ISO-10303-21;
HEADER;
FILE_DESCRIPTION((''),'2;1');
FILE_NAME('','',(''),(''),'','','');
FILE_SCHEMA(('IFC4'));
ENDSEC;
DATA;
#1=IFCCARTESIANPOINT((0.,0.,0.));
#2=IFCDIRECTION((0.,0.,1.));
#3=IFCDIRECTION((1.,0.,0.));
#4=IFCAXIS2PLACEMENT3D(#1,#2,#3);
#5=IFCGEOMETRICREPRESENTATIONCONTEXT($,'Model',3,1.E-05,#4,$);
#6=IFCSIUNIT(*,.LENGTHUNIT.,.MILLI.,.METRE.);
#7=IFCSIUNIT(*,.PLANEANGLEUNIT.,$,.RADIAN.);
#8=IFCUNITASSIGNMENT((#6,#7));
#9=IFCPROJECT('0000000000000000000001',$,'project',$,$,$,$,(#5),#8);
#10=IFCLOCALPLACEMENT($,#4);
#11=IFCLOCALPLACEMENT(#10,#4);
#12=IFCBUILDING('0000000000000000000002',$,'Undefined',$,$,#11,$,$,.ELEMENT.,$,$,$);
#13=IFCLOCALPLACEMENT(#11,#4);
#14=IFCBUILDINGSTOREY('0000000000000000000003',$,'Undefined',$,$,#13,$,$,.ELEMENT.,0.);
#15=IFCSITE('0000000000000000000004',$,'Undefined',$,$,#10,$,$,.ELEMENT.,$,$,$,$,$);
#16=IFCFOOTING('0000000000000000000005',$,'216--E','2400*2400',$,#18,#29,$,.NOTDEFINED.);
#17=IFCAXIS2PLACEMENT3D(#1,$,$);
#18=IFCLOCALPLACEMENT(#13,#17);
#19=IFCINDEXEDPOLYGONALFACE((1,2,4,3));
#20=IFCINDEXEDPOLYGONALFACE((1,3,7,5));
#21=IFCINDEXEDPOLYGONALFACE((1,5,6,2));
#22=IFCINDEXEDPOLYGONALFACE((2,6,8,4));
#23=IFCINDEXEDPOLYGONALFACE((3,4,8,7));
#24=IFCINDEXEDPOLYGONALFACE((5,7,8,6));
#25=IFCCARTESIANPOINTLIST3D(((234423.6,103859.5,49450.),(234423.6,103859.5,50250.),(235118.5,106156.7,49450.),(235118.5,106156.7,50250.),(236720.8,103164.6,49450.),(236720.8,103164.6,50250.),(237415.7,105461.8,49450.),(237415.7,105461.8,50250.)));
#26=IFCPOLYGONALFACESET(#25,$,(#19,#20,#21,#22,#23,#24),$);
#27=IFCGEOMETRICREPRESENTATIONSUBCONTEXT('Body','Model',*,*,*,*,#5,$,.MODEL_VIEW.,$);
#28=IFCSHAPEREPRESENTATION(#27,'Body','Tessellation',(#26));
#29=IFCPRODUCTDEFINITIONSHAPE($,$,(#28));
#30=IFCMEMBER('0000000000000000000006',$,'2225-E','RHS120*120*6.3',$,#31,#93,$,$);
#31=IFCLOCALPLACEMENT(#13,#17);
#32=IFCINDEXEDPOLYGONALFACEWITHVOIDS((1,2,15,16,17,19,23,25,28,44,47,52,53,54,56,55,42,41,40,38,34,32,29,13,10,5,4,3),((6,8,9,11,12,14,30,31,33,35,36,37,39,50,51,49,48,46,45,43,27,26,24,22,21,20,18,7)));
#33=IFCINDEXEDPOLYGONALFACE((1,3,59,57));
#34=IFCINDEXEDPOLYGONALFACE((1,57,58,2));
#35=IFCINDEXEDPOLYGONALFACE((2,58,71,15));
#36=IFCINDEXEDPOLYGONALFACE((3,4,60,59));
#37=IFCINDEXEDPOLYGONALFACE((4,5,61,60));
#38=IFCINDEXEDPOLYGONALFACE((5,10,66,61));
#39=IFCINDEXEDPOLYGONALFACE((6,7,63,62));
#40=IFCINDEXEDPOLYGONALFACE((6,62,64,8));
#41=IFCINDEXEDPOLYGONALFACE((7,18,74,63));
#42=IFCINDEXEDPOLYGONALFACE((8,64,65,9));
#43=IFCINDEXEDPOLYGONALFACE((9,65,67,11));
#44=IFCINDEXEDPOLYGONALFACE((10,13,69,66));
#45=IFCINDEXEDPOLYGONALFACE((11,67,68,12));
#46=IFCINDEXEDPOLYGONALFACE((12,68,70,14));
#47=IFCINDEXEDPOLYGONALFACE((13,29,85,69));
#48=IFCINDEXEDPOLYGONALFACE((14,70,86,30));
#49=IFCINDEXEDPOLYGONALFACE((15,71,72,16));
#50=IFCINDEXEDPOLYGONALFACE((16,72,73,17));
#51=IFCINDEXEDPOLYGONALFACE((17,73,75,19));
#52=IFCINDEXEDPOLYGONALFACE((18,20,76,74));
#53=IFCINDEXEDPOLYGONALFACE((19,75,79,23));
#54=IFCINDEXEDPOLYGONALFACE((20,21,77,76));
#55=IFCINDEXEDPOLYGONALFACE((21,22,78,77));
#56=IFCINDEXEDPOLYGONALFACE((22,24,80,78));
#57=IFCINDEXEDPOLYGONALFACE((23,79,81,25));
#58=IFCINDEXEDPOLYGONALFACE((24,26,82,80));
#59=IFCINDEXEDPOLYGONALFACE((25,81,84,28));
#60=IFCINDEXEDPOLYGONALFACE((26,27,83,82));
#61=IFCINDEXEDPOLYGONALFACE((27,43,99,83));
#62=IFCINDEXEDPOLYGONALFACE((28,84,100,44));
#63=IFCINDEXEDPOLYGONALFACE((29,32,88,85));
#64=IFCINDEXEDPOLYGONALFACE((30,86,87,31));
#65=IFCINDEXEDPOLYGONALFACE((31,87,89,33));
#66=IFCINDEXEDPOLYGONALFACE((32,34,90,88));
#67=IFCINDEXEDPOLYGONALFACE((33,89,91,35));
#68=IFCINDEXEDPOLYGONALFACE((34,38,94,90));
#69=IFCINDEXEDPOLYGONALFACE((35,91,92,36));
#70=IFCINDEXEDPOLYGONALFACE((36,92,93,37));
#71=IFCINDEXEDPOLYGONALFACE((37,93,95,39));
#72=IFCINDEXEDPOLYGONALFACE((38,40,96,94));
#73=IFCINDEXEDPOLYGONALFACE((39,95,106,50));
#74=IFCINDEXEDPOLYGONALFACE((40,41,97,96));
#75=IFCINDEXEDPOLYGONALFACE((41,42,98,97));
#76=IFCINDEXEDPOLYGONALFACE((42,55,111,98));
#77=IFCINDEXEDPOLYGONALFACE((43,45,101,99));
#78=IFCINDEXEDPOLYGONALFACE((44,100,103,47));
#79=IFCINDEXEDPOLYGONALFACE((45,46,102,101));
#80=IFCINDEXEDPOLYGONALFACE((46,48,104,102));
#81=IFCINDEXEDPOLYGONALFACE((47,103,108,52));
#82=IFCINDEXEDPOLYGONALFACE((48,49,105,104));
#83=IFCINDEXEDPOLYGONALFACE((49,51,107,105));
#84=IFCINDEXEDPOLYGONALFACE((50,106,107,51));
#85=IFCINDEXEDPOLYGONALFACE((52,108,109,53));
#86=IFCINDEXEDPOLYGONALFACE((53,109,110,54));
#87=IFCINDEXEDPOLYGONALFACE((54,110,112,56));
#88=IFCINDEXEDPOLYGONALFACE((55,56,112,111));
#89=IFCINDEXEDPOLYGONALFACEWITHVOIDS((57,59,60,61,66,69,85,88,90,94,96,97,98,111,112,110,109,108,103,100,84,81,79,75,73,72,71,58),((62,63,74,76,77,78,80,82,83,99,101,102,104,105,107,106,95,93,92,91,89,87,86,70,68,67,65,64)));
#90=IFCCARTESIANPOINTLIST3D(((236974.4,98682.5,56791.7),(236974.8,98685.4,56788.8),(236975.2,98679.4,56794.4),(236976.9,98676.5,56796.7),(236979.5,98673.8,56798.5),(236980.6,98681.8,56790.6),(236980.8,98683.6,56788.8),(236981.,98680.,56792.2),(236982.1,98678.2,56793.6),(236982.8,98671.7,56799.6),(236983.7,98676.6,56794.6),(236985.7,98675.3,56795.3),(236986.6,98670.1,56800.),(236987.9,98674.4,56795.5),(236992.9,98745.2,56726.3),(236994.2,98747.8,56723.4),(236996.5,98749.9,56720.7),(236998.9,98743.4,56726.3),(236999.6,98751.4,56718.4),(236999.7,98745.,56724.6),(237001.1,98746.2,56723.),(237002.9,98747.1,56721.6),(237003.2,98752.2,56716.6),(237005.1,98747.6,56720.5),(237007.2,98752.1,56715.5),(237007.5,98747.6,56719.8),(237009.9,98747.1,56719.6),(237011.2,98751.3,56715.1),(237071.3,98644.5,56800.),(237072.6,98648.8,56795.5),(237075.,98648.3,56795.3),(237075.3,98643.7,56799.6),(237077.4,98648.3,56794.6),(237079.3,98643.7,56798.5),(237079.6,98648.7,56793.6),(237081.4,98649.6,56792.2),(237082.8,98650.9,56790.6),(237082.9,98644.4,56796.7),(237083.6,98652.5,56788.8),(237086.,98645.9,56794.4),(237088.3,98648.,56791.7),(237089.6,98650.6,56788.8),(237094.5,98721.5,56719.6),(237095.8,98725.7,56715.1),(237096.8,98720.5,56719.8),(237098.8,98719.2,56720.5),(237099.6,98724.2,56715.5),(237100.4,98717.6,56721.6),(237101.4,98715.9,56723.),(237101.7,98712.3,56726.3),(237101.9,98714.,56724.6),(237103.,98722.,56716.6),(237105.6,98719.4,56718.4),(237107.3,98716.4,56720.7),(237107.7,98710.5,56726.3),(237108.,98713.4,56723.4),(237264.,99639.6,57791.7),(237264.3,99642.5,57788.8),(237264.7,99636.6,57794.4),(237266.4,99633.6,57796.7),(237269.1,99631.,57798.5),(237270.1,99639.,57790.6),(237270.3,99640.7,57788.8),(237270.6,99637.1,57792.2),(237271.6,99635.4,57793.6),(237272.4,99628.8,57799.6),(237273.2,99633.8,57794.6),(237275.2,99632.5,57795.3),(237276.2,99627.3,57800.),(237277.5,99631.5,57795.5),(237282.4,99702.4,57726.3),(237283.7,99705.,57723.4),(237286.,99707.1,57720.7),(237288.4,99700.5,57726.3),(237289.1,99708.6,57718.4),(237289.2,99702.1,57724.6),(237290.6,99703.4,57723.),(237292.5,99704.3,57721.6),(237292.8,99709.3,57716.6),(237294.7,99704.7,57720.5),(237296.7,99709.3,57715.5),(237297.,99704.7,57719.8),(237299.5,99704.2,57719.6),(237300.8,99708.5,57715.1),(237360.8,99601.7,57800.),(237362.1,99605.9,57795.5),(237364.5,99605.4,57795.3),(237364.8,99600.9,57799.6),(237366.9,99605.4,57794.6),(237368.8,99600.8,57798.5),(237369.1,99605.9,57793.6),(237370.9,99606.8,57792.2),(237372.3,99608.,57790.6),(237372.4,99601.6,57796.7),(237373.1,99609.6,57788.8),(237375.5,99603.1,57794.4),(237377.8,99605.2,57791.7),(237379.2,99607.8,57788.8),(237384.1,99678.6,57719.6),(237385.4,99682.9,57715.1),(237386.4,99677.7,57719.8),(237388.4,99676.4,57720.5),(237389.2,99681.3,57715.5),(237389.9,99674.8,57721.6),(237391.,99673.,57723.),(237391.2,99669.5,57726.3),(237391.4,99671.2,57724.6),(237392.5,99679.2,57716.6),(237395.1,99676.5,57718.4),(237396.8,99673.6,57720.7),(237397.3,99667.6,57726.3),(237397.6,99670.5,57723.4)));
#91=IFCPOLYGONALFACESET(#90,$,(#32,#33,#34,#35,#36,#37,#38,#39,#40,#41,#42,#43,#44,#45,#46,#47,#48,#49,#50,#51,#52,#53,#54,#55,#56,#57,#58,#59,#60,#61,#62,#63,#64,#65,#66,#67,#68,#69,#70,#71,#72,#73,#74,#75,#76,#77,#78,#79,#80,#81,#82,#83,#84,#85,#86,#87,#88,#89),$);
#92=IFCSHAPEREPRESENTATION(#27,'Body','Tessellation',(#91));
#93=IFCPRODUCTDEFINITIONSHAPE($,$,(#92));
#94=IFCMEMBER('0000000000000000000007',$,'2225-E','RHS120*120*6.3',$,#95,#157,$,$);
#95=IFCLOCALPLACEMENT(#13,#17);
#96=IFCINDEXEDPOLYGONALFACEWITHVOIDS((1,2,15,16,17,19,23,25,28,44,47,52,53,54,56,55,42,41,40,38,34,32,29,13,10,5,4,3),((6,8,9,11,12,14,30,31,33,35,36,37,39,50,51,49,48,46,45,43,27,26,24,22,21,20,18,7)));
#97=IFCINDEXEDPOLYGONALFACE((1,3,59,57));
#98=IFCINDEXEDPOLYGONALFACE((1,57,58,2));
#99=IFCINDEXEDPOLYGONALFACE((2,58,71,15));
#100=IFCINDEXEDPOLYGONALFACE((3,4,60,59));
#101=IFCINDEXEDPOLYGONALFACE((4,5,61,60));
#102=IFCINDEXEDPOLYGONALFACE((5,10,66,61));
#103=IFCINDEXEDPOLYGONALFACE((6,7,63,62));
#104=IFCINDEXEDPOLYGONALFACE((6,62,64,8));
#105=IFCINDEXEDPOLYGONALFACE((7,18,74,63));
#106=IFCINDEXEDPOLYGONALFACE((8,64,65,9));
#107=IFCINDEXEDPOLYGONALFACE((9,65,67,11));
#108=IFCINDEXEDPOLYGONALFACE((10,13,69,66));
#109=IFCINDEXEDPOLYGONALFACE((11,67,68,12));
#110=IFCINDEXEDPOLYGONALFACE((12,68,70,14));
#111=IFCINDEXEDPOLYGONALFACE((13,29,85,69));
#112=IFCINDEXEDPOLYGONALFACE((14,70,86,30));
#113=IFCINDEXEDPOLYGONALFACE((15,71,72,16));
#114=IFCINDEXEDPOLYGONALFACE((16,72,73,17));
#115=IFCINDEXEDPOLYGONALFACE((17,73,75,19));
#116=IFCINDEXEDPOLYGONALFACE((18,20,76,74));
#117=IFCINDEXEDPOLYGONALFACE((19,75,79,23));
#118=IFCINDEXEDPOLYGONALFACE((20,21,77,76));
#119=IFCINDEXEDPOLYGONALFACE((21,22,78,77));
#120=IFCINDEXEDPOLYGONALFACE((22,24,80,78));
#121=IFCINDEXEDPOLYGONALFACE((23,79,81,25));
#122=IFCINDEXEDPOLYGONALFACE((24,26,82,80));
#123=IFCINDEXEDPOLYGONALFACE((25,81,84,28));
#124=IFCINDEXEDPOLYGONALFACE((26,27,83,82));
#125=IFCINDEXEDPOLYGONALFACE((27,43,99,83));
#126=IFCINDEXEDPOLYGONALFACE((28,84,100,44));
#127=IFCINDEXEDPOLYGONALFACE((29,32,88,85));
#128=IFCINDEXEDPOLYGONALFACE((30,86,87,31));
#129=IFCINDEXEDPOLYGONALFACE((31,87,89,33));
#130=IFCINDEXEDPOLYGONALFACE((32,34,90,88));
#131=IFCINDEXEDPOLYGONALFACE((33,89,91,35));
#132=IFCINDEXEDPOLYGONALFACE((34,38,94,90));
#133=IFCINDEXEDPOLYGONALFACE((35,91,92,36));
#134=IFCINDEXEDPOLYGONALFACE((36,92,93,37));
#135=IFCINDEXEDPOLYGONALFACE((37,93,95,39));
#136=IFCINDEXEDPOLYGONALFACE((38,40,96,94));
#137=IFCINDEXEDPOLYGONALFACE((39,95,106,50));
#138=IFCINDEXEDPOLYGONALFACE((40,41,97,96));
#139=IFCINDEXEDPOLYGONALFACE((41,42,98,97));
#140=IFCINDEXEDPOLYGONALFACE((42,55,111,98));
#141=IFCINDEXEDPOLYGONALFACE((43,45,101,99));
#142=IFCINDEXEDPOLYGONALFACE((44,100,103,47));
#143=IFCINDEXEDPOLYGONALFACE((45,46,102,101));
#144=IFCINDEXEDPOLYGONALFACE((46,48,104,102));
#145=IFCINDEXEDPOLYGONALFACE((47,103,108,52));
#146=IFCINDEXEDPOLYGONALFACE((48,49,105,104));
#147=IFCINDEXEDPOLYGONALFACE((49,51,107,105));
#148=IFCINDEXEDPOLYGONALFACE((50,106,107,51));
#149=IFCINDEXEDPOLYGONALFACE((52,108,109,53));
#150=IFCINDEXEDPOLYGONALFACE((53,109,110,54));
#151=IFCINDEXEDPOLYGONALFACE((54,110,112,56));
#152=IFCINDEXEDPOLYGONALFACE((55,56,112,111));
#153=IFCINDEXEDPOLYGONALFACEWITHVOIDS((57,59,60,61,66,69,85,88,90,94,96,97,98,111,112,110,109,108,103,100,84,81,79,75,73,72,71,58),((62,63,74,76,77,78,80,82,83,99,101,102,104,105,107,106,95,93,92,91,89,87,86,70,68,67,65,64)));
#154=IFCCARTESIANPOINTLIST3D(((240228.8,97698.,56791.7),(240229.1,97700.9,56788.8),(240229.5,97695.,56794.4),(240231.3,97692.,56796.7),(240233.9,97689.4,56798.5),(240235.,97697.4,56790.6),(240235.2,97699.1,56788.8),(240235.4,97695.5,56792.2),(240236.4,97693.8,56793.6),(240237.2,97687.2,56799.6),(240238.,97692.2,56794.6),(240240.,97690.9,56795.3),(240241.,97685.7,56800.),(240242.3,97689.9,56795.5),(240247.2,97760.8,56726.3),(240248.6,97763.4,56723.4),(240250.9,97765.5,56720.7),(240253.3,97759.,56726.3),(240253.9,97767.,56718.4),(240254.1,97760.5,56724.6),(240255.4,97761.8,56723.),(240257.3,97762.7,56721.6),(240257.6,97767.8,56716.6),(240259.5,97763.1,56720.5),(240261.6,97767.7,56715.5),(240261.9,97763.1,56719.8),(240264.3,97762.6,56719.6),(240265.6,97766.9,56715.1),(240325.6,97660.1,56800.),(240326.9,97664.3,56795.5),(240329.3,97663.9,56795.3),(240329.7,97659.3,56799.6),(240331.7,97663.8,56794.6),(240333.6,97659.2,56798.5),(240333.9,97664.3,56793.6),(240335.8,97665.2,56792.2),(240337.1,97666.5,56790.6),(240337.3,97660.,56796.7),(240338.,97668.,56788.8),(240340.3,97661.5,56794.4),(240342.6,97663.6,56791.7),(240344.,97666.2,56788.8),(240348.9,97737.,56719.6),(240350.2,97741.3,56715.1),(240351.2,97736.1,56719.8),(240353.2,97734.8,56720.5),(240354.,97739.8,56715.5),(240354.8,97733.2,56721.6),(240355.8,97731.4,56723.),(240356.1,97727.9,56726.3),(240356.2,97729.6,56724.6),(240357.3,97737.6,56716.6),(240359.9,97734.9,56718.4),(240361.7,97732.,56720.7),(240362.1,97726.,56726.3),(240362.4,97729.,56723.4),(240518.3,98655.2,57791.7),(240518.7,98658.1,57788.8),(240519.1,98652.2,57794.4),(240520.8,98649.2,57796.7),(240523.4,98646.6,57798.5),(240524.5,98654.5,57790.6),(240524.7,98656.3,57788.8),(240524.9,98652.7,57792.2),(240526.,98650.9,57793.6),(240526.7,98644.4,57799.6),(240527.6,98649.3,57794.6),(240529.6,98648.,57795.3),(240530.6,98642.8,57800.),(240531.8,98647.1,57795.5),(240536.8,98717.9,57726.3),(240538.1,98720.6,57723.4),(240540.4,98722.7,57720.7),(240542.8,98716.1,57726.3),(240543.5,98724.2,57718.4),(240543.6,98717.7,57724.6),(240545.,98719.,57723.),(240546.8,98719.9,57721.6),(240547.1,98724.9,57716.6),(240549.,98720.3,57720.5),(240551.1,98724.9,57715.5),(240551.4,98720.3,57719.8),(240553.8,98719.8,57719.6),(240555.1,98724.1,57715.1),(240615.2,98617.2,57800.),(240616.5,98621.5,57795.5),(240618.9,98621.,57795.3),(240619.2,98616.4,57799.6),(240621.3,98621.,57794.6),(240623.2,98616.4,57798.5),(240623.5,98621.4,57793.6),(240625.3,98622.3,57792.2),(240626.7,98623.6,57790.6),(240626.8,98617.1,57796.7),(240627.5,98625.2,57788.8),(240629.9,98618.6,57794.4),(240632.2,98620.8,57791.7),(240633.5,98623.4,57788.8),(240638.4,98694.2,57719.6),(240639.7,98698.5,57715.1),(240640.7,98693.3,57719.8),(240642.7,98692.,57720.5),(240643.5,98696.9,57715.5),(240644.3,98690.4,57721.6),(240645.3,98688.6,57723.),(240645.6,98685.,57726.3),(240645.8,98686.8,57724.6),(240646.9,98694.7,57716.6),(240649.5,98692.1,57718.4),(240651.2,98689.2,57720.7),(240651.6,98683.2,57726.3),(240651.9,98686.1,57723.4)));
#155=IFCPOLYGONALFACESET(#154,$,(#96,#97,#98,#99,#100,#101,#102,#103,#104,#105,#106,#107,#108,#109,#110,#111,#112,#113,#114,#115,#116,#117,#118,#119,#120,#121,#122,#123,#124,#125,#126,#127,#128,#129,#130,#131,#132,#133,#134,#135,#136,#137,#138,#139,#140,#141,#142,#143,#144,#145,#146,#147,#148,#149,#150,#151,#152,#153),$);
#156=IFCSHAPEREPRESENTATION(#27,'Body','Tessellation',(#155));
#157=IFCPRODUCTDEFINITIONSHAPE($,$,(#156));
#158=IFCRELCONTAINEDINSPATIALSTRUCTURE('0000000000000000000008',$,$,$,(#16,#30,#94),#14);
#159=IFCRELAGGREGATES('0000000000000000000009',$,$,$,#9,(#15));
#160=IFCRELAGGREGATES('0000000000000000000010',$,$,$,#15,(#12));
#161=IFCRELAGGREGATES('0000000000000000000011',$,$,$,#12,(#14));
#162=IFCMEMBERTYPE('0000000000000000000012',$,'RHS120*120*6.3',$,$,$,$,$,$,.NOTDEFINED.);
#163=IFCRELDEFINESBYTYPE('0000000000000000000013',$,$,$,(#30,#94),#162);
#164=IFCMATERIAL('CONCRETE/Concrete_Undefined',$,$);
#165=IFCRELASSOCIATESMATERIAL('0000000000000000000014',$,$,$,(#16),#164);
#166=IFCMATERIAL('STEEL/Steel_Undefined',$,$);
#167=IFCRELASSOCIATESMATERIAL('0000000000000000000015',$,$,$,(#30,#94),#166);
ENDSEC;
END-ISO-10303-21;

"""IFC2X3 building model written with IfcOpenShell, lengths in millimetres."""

from ifc_helpers import new_model, si_unit, frame, origin_with_axes, origin_2d_with_axis, place, context, subcontext, project, spatial, rectangle, hollow_rectangle, extrude, material, type_object, element, save


model = new_model("IFC2X3")

# Units and contexts
model_context = context("Model", 3, precision=1e-05, world=origin_with_axes())
body_context = subcontext(model_context, "Body", "Model", "MODEL_VIEW")
ifc_project = project(units=[si_unit("LENGTHUNIT", "METRE", prefix="MILLI"), si_unit("PLANEANGLEUNIT", "RADIAN")], contexts=[model_context])

# Site, building, storey
site_placement = place(None, origin_with_axes())
site = spatial("IfcSite", under=ifc_project, at=site_placement, Name="Undefined", CompositionType="ELEMENT")
building_placement = place(site_placement, origin_with_axes())
building = spatial("IfcBuilding", under=site, at=building_placement, Name="Undefined", CompositionType="ELEMENT")
storey_placement = place(building_placement, origin_with_axes())
storey = spatial("IfcBuildingStorey", under=building, at=storey_placement, Name="Undefined", CompositionType="ELEMENT", Elevation=0.0)

# Footing
ifc_material_1 = material(Name="CONCRETE/Concrete_Undefined")
footing_placement = place(storey_placement, frame((235919.6, 104660.6, 49450.0), z_axis=(0.289538, 0.957166, 0.0), x_axis=(0.0, 0.0, 1.0)))
element("IfcFooting", 1, at=footing_placement, inside=storey, material=ifc_material_1, Name="216--E", Description="2400*2400", PredefinedType="NOTDEFINED", context=body_context, shape_type="SweptSolid", body=[
    extrude(rectangle(XDim=2400.0, YDim=2400.0, at=origin_2d_with_axis()), frame((800.0, 0.0, 0.0), z_axis=(-1.0, 0.0, 0.0), x_axis=(0.0, -1.0, 0.0)), (0.0, 0.0, 1.0), 800.0),
])

# Members
ifc_material_2 = material(Name="STEEL/Steel_Undefined")
member_type = type_object("IfcMemberType", Name="RHS120*120*6.3", PredefinedType="NOTDEFINED")
for number, where, z_axis, x_axis, name in (
    (2, (237041.2, 98697.9, 56757.6), (-0.204734, -0.676819, 0.707107), (0.204734, 0.676819, 0.707107), "2225-E"),
    (3, (240295.6, 97713.5, 56757.6), (-0.204734, -0.676819, 0.707107), (0.204734, 0.676819, 0.707107), "2225-E"),
):
    element("IfcMember", number, at=place(storey_placement, frame(where, z_axis=z_axis, x_axis=x_axis)), inside=storey, type_object=member_type, material=ifc_material_2, Name=name, Description="RHS120*120*6.3", context=body_context, shape_type="SweptSolid", body=[
        extrude(hollow_rectangle(XDim=120.0, YDim=120.0, WallThickness=6.3, InnerFilletRadius=9.5, OuterFilletRadius=15.8, at=origin_2d_with_axis()), frame((1414.2, 0.0, 0.0), z_axis=(-1.0, 0.0, 0.0), x_axis=(0.0, -1.0, 0.0)), (0.0, 0.0, 1.0), 1414.2),
    ])

save(model, "model.ifc")
